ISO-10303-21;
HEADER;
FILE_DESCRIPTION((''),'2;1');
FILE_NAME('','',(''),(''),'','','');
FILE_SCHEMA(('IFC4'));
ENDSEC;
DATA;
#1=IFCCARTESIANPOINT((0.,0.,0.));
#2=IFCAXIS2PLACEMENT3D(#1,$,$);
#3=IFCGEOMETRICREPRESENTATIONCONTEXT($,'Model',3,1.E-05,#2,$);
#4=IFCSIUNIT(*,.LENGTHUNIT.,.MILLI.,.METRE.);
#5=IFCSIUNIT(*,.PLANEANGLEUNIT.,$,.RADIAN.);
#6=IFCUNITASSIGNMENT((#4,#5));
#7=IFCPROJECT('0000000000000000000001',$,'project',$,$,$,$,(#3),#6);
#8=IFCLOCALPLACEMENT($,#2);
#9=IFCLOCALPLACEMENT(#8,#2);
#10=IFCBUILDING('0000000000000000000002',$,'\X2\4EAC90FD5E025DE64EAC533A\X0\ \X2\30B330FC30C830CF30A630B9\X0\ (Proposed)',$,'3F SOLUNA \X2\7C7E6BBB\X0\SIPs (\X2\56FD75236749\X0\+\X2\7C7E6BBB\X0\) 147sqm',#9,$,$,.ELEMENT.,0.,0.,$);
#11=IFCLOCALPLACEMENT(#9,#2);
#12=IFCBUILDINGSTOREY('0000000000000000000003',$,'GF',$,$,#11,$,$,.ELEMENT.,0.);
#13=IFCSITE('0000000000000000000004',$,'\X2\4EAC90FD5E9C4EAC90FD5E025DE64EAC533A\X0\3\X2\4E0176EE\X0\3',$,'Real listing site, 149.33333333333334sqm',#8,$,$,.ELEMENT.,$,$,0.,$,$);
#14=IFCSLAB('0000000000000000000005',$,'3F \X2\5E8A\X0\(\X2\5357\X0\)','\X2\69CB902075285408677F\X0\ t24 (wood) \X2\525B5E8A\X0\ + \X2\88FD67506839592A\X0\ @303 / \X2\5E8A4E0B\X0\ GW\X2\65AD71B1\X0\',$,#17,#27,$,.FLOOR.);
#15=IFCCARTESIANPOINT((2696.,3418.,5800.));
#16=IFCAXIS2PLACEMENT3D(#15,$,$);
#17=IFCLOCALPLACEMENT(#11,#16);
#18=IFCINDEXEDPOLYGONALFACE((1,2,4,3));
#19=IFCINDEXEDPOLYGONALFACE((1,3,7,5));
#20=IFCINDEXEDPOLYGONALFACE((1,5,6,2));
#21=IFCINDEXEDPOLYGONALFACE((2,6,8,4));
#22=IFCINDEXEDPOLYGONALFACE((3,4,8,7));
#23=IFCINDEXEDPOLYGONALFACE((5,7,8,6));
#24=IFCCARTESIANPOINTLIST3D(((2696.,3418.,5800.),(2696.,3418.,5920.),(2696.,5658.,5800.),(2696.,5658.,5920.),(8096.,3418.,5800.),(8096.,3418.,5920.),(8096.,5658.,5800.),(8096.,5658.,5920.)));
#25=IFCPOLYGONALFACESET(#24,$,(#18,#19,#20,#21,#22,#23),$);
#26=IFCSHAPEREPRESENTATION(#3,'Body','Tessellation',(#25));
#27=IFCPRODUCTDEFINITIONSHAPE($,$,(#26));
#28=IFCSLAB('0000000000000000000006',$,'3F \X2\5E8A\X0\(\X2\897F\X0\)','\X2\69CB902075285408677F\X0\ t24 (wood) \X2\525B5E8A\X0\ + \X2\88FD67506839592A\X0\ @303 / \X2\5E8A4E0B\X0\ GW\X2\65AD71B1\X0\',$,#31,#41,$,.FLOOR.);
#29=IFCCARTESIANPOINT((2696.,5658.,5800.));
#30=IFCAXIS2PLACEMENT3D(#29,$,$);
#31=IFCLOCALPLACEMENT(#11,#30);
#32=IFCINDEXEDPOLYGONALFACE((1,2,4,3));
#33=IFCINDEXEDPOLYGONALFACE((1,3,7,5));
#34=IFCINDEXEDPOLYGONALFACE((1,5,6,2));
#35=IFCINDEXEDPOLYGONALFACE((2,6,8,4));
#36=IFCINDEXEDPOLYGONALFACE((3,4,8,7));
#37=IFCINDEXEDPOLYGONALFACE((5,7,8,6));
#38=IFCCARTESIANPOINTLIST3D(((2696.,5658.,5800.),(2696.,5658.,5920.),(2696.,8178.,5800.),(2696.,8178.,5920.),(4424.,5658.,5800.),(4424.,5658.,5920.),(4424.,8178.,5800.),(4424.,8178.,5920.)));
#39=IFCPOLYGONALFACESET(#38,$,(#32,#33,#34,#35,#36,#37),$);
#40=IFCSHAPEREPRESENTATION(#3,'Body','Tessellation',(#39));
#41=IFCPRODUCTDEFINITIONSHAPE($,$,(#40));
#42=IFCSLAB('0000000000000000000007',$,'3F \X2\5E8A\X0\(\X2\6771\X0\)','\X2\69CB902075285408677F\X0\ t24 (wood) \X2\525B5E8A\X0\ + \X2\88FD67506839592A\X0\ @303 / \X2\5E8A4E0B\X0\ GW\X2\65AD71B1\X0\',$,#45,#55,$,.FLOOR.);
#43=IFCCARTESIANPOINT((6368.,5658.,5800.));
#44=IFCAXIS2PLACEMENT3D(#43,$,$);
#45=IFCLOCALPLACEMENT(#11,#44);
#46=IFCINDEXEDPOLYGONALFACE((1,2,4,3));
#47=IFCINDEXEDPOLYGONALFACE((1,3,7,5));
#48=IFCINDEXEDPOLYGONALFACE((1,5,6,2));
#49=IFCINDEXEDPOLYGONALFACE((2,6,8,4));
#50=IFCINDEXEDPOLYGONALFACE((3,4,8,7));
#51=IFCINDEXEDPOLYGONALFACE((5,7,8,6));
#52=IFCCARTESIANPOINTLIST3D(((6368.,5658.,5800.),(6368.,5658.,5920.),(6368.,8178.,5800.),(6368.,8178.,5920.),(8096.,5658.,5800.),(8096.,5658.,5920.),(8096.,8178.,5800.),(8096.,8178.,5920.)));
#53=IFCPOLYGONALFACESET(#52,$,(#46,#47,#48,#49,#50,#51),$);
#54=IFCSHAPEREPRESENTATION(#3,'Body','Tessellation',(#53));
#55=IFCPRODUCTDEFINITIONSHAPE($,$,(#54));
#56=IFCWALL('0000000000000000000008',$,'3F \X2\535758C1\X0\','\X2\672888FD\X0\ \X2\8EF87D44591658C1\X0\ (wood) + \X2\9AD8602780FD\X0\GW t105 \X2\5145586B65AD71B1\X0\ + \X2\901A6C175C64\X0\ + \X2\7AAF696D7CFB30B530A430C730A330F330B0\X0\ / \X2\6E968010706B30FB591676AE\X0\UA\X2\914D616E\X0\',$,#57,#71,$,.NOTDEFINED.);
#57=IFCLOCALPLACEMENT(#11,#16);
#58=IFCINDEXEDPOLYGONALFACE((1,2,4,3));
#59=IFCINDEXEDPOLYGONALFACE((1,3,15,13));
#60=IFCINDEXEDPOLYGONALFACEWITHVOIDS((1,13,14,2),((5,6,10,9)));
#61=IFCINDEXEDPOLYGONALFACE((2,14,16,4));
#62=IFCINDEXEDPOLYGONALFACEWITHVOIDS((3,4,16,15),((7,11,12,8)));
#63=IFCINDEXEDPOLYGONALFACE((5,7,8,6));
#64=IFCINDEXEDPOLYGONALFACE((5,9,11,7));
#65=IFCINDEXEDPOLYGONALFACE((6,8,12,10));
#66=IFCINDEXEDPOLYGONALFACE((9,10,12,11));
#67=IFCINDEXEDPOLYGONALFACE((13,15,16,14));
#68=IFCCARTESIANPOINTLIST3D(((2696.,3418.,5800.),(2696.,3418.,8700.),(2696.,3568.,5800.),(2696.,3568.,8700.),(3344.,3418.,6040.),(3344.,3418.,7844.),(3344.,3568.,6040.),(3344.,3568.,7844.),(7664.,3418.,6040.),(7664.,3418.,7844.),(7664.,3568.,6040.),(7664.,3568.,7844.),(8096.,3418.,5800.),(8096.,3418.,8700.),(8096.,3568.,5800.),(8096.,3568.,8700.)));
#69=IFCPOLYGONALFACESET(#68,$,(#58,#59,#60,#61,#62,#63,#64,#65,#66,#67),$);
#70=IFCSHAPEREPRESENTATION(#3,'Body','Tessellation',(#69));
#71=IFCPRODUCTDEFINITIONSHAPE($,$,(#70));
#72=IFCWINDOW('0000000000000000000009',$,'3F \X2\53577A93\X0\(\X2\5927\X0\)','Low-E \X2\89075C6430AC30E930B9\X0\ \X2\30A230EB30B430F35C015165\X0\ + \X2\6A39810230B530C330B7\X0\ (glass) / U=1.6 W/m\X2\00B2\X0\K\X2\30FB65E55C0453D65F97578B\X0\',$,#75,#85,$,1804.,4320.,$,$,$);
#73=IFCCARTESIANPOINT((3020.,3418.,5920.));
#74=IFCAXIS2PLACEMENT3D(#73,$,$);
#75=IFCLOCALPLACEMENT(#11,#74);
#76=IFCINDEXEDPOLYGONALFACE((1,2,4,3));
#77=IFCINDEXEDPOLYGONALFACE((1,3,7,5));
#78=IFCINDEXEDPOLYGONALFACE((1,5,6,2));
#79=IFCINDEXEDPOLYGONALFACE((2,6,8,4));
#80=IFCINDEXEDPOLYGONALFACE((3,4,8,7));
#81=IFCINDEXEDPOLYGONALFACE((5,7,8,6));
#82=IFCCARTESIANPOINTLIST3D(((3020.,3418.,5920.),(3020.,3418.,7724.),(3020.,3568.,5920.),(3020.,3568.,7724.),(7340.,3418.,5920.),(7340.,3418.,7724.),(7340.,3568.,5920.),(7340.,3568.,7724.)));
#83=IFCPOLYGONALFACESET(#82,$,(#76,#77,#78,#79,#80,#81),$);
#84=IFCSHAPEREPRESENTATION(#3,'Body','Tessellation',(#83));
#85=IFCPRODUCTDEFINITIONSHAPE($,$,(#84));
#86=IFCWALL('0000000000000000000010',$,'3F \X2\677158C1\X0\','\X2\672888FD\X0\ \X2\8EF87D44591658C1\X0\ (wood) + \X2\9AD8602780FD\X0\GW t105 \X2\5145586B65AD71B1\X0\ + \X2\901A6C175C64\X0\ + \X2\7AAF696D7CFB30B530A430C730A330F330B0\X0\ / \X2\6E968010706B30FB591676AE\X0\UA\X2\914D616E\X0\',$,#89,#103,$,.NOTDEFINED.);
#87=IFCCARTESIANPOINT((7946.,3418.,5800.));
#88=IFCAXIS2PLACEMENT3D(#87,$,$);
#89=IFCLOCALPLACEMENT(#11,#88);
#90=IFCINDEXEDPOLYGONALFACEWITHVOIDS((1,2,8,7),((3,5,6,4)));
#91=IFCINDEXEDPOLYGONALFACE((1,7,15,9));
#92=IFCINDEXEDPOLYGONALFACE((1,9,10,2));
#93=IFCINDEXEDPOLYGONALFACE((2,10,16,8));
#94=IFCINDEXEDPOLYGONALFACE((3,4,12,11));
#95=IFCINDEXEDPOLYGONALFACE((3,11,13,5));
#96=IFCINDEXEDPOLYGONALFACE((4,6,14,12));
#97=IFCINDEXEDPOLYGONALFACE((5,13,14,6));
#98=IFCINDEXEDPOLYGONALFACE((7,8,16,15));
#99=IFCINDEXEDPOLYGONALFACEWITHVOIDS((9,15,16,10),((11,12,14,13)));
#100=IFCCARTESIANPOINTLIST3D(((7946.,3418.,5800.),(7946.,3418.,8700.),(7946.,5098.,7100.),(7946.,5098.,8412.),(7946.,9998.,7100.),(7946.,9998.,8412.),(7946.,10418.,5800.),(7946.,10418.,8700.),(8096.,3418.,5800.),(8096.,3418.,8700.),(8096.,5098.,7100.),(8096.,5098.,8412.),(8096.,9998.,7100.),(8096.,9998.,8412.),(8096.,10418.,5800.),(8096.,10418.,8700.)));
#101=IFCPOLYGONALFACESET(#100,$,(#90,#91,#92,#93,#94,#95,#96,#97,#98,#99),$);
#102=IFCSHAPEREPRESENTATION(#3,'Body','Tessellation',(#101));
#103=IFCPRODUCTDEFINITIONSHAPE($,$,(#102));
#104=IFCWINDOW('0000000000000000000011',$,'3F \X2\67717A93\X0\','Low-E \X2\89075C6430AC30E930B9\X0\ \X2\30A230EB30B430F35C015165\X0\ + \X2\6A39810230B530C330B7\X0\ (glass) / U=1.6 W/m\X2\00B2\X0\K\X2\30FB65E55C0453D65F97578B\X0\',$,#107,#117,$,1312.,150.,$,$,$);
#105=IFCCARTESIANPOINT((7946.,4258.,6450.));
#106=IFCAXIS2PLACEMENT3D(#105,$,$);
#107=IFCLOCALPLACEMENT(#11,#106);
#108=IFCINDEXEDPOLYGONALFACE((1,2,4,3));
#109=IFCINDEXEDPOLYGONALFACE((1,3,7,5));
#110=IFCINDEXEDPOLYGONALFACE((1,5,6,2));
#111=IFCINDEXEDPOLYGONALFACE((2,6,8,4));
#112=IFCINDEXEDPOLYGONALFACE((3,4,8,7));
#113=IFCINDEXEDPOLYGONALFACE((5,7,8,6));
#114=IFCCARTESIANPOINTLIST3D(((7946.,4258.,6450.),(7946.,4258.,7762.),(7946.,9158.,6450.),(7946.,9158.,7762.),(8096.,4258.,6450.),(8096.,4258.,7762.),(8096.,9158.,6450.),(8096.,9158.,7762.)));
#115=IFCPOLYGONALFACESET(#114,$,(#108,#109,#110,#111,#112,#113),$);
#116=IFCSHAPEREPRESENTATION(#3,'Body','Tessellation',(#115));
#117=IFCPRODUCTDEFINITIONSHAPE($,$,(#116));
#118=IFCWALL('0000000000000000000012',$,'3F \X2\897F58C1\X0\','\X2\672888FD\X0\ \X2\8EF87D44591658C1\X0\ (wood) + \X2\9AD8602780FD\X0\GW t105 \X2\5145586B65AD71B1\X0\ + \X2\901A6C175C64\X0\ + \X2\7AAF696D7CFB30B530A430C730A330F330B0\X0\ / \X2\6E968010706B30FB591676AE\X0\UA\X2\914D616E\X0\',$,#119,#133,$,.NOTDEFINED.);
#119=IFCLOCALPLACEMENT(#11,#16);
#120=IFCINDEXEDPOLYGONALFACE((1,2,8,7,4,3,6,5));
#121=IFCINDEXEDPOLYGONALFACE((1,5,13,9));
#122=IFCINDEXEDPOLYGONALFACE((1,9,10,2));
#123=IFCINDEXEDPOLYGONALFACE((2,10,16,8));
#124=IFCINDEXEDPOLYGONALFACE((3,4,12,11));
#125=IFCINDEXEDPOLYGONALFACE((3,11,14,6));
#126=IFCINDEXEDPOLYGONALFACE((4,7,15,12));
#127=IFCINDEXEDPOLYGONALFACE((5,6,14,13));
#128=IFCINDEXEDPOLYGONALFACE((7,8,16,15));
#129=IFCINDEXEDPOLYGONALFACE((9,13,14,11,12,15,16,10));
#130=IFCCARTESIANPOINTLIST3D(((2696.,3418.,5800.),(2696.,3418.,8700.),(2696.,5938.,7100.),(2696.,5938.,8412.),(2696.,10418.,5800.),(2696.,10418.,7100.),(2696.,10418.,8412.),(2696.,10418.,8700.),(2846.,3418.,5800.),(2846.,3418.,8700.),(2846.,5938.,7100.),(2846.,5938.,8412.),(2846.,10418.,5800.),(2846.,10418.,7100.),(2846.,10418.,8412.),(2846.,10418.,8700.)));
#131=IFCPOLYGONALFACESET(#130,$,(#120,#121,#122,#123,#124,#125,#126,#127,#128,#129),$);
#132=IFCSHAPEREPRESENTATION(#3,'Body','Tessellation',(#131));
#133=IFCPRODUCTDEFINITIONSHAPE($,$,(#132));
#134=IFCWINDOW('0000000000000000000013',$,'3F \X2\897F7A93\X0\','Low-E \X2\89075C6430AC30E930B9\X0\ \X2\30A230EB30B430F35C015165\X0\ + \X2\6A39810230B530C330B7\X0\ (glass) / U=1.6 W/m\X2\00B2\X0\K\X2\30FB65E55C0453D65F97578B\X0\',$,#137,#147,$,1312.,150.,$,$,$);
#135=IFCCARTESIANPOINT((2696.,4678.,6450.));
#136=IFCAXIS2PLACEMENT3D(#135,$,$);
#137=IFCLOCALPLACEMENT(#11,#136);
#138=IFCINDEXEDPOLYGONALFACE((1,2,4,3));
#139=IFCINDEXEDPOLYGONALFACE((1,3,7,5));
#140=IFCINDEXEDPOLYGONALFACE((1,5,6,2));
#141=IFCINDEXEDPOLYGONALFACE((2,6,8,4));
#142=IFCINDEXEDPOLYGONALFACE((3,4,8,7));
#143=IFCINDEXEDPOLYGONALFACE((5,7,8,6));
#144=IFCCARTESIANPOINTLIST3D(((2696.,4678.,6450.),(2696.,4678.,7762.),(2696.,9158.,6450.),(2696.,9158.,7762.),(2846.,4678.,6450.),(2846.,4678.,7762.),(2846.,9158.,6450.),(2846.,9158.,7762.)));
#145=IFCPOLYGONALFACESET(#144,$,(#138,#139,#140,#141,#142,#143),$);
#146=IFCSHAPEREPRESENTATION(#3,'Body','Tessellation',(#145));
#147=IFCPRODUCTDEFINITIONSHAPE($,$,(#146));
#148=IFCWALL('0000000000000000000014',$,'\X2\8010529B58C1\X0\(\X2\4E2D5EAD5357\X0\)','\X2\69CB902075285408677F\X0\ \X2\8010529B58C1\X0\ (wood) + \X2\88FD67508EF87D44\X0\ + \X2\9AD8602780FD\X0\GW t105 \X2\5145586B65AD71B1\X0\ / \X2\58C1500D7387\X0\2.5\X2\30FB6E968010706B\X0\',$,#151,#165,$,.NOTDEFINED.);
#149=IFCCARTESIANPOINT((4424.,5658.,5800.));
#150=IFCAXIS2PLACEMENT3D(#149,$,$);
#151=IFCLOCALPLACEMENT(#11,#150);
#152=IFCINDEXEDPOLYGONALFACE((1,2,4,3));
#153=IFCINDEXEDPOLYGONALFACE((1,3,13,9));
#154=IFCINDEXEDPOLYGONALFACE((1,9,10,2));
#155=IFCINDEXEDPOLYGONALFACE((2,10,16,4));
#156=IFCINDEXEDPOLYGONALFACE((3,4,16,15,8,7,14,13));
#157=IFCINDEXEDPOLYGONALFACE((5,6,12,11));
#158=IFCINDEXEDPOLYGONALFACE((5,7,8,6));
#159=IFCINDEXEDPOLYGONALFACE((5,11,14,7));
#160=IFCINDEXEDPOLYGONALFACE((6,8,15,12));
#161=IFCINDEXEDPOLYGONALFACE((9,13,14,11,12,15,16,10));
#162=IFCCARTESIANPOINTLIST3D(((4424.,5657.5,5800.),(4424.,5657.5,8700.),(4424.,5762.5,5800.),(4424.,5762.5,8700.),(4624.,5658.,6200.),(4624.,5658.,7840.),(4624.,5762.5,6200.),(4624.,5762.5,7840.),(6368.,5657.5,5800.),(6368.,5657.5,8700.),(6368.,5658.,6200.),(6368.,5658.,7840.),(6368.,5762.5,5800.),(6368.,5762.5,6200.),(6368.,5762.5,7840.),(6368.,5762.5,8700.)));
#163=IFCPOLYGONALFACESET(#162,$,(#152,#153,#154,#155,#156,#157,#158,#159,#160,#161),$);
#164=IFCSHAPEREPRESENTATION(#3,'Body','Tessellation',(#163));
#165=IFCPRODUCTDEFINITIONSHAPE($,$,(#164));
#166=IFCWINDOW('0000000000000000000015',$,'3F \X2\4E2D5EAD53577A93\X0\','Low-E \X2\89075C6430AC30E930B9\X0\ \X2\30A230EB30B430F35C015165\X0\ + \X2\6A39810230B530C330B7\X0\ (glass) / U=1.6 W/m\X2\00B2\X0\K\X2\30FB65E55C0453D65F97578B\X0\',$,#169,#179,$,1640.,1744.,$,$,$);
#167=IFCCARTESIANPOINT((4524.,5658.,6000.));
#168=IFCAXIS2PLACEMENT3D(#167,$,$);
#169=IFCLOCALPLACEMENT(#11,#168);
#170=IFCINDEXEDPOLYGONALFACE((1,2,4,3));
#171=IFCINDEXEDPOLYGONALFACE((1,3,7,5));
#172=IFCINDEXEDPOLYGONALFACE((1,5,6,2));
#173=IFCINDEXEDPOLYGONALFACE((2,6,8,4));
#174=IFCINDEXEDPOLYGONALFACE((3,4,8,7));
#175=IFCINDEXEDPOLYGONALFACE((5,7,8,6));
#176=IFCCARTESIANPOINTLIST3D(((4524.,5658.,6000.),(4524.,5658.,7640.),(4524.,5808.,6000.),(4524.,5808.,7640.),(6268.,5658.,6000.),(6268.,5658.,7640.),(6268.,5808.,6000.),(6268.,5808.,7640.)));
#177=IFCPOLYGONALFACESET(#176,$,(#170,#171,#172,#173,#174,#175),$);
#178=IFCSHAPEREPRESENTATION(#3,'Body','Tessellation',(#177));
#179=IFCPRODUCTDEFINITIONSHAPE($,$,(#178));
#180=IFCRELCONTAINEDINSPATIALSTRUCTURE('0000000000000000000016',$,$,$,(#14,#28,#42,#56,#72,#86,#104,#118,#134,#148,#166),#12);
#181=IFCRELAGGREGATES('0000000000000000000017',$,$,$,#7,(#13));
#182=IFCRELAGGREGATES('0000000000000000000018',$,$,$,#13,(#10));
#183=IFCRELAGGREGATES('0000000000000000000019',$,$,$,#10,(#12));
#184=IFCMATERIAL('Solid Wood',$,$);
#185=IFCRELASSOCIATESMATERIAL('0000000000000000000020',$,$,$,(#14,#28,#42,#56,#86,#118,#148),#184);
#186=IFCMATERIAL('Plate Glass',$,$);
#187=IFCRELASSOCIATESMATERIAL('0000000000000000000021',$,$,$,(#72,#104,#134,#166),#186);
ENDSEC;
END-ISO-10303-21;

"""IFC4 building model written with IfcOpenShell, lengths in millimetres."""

from ifc_helpers import new_model, si_unit, frame, frame_2d, origin, place, context, project, spatial, rectangle, extrude, material, element, fill, save


model = new_model("IFC4")

# Units and contexts
model_context = context("Model", 3, precision=1e-05, world=origin())
ifc_project = project(units=[si_unit("LENGTHUNIT", "METRE", prefix="MILLI"), si_unit("PLANEANGLEUNIT", "RADIAN")], contexts=[model_context])

# Site, building, storey
site_placement = place(None, origin())
site = spatial("IfcSite", under=ifc_project, at=site_placement, Name="京都府京都市左京区3丁目3", ObjectType="Real listing site, 149.33333333333334sqm", CompositionType="ELEMENT", RefElevation=0.0)
building_placement = place(site_placement, origin())
building = spatial("IfcBuilding", under=site, at=building_placement, Name="京都市左京区 コートハウス (Proposed)", ObjectType="3F SOLUNA 籾殻SIPs (国産杉+籾殻) 147sqm", CompositionType="ELEMENT", ElevationOfRefHeight=0.0, ElevationOfTerrain=0.0)
storey_placement = place(building_placement, origin())
storey = spatial("IfcBuildingStorey", under=building, at=storey_placement, Name="GF", CompositionType="ELEMENT", Elevation=0.0)

# Slabs
ifc_material_1 = material(Name="Solid Wood")
slab_1_placement = place(storey_placement, frame((2696.0, 3418.0, 5800.0)))
element("IfcSlab", 1, at=slab_1_placement, inside=storey, material=ifc_material_1, Name="3F 床(南)", Description="構造用合板 t24 (wood) 剛床 + 製材根太 @303 / 床下 GW断熱", PredefinedType="FLOOR", context=model_context, shape_type="SweptSolid", body=[
    extrude(rectangle(XDim=5400.0, YDim=2240.0, at=frame_2d((2700.0, 1120.0))), frame((2696.0, 3418.0, 5800.0)), (0.0, 0.0, 1.0), 120.0),
])
slab_2_placement = place(storey_placement, frame((2696.0, 5658.0, 5800.0)))
element("IfcSlab", 2, at=slab_2_placement, inside=storey, material=ifc_material_1, Name="3F 床(西)", Description="構造用合板 t24 (wood) 剛床 + 製材根太 @303 / 床下 GW断熱", PredefinedType="FLOOR", context=model_context, shape_type="SweptSolid", body=[
    extrude(rectangle(XDim=1728.0, YDim=2520.0, at=frame_2d((864.0, 1260.0))), frame((2696.0, 5658.0, 5800.0)), (0.0, 0.0, 1.0), 120.0),
])
slab_3_placement = place(storey_placement, frame((6368.0, 5658.0, 5800.0)))
element("IfcSlab", 3, at=slab_3_placement, inside=storey, material=ifc_material_1, Name="3F 床(東)", Description="構造用合板 t24 (wood) 剛床 + 製材根太 @303 / 床下 GW断熱", PredefinedType="FLOOR", context=model_context, shape_type="SweptSolid", body=[
    extrude(rectangle(XDim=1728.0, YDim=2520.0, at=frame_2d((864.0, 1260.0))), frame((6368.0, 5658.0, 5800.0)), (0.0, 0.0, 1.0), 120.0),
])

# Walls, openings, windows
wall_1_placement = place(storey_placement, frame((2696.0, 3418.0, 5800.0)))
wall_1 = element("IfcWall", 4, at=wall_1_placement, inside=storey, material=ifc_material_1, Name="3F 南壁", Description="木製 軸組外壁 (wood) + 高性能GW t105 充填断熱 + 通気層 + 窯業系サイディング / 準耐火・外皮UA配慮", PredefinedType="NOTDEFINED", context=model_context, shape_type="SweptSolid", body=[
    extrude(rectangle(XDim=5400.0, YDim=150.0, at=frame_2d((2700.0, 75.0))), frame((2696.0, 3418.0, 5800.0)), (0.0, 0.0, 1.0), 2900.0),
])
opening_1_placement = place(storey_placement, frame((3020.0, 3418.0, 5920.0)))
opening_1 = element("IfcOpeningElement", 5, at=opening_1_placement, cuts=wall_1, PredefinedType="NOTDEFINED", context=model_context, shape_type="SweptSolid", body=[
    extrude(rectangle(XDim=4320.0, YDim=150.0, at=frame_2d((2160.0, 75.0))), frame((3020.0, 3418.0, 5920.0)), (0.0, 0.0, 1.0), 1804.0),
])
ifc_material_2 = material(Name="Plate Glass")
window_1_placement = place(storey_placement, frame((3020.0, 3418.0, 5920.0)))
window_1 = element("IfcWindow", 6, at=window_1_placement, inside=storey, material=ifc_material_2, Name="3F 南窓(大)", Description="Low-E 複層ガラス アルゴン封入 + 樹脂サッシ (glass) / U=1.6 W/m²K・日射取得型", OverallHeight=1804.0, OverallWidth=4320.0, context=model_context, shape_type="SweptSolid", body=[
    extrude(rectangle(XDim=4320.0, YDim=150.0, at=frame_2d((2160.0, 75.0))), frame((3020.0, 3418.0, 5920.0)), (0.0, 0.0, 1.0), 1804.0),
])
fill(opening_1, window_1)
wall_2_placement = place(storey_placement, frame((7946.0, 3418.0, 5800.0)))
wall_2 = element("IfcWall", 7, at=wall_2_placement, inside=storey, material=ifc_material_1, Name="3F 東壁", Description="木製 軸組外壁 (wood) + 高性能GW t105 充填断熱 + 通気層 + 窯業系サイディング / 準耐火・外皮UA配慮", PredefinedType="NOTDEFINED", context=model_context, shape_type="SweptSolid", body=[
    extrude(rectangle(XDim=150.0, YDim=7000.0, at=frame_2d((75.0, 3500.0))), frame((7946.0, 3418.0, 5800.0)), (0.0, 0.0, 1.0), 2900.0),
])
opening_2_placement = place(storey_placement, frame((7946.0, 4258.0, 6450.0)))
opening_2 = element("IfcOpeningElement", 8, at=opening_2_placement, cuts=wall_2, PredefinedType="NOTDEFINED", context=model_context, shape_type="SweptSolid", body=[
    extrude(rectangle(XDim=150.0, YDim=4900.0, at=frame_2d((75.0, 2450.0))), frame((7946.0, 4258.0, 6450.0)), (0.0, 0.0, 1.0), 1312.0),
])
window_2_placement = place(storey_placement, frame((7946.0, 4258.0, 6450.0)))
window_2 = element("IfcWindow", 9, at=window_2_placement, inside=storey, material=ifc_material_2, Name="3F 東窓", Description="Low-E 複層ガラス アルゴン封入 + 樹脂サッシ (glass) / U=1.6 W/m²K・日射取得型", OverallHeight=1312.0, OverallWidth=150.0, context=model_context, shape_type="SweptSolid", body=[
    extrude(rectangle(XDim=150.0, YDim=4900.0, at=frame_2d((75.0, 2450.0))), frame((7946.0, 4258.0, 6450.0)), (0.0, 0.0, 1.0), 1312.0),
])
fill(opening_2, window_2)
wall_3_placement = place(storey_placement, frame((2696.0, 3418.0, 5800.0)))
wall_3 = element("IfcWall", 10, at=wall_3_placement, inside=storey, material=ifc_material_1, Name="3F 西壁", Description="木製 軸組外壁 (wood) + 高性能GW t105 充填断熱 + 通気層 + 窯業系サイディング / 準耐火・外皮UA配慮", PredefinedType="NOTDEFINED", context=model_context, shape_type="SweptSolid", body=[
    extrude(rectangle(XDim=150.0, YDim=7000.0, at=frame_2d((75.0, 3500.0))), frame((2696.0, 3418.0, 5800.0)), (0.0, 0.0, 1.0), 2900.0),
])
opening_3_placement = place(storey_placement, frame((2696.0, 4678.0, 6450.0)))
opening_3 = element("IfcOpeningElement", 11, at=opening_3_placement, cuts=wall_3, PredefinedType="NOTDEFINED", context=model_context, shape_type="SweptSolid", body=[
    extrude(rectangle(XDim=150.0, YDim=4480.0, at=frame_2d((75.0, 2240.0))), frame((2696.0, 4678.0, 6450.0)), (0.0, 0.0, 1.0), 1312.0),
])
window_3_placement = place(storey_placement, frame((2696.0, 4678.0, 6450.0)))
window_3 = element("IfcWindow", 12, at=window_3_placement, inside=storey, material=ifc_material_2, Name="3F 西窓", Description="Low-E 複層ガラス アルゴン封入 + 樹脂サッシ (glass) / U=1.6 W/m²K・日射取得型", OverallHeight=1312.0, OverallWidth=150.0, context=model_context, shape_type="SweptSolid", body=[
    extrude(rectangle(XDim=150.0, YDim=4480.0, at=frame_2d((75.0, 2240.0))), frame((2696.0, 4678.0, 6450.0)), (0.0, 0.0, 1.0), 1312.0),
])
fill(opening_3, window_3)
wall_4_placement = place(storey_placement, frame((4424.0, 5658.0, 5800.0)))
wall_4 = element("IfcWall", 13, at=wall_4_placement, inside=storey, material=ifc_material_1, Name="耐力壁(中庭南)", Description="構造用合板 耐力壁 (wood) + 製材軸組 + 高性能GW t105 充填断熱 / 壁倍率2.5・準耐火", PredefinedType="NOTDEFINED", context=model_context, shape_type="SweptSolid", body=[
    extrude(rectangle(XDim=1944.0, YDim=105.0, at=frame_2d((972.0, 52.0))), frame((4424.0, 5658.0, 5800.0)), (0.0, 0.0, 1.0), 2900.0),
])
opening_4_placement = place(storey_placement, frame((4524.0, 5658.0, 6000.0)))
opening_4 = element("IfcOpeningElement", 14, at=opening_4_placement, cuts=wall_4, PredefinedType="NOTDEFINED", context=model_context, shape_type="SweptSolid", body=[
    extrude(rectangle(XDim=1744.0, YDim=150.0, at=frame_2d((872.0, 75.0))), frame((4524.0, 5658.0, 6000.0)), (0.0, 0.0, 1.0), 1640.0),
])
window_4_placement = place(storey_placement, frame((4524.0, 5658.0, 6000.0)))
window_4 = element("IfcWindow", 15, at=window_4_placement, inside=storey, material=ifc_material_2, Name="3F 中庭南窓", Description="Low-E 複層ガラス アルゴン封入 + 樹脂サッシ (glass) / U=1.6 W/m²K・日射取得型", OverallHeight=1640.0, OverallWidth=1744.0, context=model_context, shape_type="SweptSolid", body=[
    extrude(rectangle(XDim=1744.0, YDim=150.0, at=frame_2d((872.0, 75.0))), frame((4524.0, 5658.0, 6000.0)), (0.0, 0.0, 1.0), 1640.0),
])
fill(opening_4, window_4)

save(model, "model.ifc")
